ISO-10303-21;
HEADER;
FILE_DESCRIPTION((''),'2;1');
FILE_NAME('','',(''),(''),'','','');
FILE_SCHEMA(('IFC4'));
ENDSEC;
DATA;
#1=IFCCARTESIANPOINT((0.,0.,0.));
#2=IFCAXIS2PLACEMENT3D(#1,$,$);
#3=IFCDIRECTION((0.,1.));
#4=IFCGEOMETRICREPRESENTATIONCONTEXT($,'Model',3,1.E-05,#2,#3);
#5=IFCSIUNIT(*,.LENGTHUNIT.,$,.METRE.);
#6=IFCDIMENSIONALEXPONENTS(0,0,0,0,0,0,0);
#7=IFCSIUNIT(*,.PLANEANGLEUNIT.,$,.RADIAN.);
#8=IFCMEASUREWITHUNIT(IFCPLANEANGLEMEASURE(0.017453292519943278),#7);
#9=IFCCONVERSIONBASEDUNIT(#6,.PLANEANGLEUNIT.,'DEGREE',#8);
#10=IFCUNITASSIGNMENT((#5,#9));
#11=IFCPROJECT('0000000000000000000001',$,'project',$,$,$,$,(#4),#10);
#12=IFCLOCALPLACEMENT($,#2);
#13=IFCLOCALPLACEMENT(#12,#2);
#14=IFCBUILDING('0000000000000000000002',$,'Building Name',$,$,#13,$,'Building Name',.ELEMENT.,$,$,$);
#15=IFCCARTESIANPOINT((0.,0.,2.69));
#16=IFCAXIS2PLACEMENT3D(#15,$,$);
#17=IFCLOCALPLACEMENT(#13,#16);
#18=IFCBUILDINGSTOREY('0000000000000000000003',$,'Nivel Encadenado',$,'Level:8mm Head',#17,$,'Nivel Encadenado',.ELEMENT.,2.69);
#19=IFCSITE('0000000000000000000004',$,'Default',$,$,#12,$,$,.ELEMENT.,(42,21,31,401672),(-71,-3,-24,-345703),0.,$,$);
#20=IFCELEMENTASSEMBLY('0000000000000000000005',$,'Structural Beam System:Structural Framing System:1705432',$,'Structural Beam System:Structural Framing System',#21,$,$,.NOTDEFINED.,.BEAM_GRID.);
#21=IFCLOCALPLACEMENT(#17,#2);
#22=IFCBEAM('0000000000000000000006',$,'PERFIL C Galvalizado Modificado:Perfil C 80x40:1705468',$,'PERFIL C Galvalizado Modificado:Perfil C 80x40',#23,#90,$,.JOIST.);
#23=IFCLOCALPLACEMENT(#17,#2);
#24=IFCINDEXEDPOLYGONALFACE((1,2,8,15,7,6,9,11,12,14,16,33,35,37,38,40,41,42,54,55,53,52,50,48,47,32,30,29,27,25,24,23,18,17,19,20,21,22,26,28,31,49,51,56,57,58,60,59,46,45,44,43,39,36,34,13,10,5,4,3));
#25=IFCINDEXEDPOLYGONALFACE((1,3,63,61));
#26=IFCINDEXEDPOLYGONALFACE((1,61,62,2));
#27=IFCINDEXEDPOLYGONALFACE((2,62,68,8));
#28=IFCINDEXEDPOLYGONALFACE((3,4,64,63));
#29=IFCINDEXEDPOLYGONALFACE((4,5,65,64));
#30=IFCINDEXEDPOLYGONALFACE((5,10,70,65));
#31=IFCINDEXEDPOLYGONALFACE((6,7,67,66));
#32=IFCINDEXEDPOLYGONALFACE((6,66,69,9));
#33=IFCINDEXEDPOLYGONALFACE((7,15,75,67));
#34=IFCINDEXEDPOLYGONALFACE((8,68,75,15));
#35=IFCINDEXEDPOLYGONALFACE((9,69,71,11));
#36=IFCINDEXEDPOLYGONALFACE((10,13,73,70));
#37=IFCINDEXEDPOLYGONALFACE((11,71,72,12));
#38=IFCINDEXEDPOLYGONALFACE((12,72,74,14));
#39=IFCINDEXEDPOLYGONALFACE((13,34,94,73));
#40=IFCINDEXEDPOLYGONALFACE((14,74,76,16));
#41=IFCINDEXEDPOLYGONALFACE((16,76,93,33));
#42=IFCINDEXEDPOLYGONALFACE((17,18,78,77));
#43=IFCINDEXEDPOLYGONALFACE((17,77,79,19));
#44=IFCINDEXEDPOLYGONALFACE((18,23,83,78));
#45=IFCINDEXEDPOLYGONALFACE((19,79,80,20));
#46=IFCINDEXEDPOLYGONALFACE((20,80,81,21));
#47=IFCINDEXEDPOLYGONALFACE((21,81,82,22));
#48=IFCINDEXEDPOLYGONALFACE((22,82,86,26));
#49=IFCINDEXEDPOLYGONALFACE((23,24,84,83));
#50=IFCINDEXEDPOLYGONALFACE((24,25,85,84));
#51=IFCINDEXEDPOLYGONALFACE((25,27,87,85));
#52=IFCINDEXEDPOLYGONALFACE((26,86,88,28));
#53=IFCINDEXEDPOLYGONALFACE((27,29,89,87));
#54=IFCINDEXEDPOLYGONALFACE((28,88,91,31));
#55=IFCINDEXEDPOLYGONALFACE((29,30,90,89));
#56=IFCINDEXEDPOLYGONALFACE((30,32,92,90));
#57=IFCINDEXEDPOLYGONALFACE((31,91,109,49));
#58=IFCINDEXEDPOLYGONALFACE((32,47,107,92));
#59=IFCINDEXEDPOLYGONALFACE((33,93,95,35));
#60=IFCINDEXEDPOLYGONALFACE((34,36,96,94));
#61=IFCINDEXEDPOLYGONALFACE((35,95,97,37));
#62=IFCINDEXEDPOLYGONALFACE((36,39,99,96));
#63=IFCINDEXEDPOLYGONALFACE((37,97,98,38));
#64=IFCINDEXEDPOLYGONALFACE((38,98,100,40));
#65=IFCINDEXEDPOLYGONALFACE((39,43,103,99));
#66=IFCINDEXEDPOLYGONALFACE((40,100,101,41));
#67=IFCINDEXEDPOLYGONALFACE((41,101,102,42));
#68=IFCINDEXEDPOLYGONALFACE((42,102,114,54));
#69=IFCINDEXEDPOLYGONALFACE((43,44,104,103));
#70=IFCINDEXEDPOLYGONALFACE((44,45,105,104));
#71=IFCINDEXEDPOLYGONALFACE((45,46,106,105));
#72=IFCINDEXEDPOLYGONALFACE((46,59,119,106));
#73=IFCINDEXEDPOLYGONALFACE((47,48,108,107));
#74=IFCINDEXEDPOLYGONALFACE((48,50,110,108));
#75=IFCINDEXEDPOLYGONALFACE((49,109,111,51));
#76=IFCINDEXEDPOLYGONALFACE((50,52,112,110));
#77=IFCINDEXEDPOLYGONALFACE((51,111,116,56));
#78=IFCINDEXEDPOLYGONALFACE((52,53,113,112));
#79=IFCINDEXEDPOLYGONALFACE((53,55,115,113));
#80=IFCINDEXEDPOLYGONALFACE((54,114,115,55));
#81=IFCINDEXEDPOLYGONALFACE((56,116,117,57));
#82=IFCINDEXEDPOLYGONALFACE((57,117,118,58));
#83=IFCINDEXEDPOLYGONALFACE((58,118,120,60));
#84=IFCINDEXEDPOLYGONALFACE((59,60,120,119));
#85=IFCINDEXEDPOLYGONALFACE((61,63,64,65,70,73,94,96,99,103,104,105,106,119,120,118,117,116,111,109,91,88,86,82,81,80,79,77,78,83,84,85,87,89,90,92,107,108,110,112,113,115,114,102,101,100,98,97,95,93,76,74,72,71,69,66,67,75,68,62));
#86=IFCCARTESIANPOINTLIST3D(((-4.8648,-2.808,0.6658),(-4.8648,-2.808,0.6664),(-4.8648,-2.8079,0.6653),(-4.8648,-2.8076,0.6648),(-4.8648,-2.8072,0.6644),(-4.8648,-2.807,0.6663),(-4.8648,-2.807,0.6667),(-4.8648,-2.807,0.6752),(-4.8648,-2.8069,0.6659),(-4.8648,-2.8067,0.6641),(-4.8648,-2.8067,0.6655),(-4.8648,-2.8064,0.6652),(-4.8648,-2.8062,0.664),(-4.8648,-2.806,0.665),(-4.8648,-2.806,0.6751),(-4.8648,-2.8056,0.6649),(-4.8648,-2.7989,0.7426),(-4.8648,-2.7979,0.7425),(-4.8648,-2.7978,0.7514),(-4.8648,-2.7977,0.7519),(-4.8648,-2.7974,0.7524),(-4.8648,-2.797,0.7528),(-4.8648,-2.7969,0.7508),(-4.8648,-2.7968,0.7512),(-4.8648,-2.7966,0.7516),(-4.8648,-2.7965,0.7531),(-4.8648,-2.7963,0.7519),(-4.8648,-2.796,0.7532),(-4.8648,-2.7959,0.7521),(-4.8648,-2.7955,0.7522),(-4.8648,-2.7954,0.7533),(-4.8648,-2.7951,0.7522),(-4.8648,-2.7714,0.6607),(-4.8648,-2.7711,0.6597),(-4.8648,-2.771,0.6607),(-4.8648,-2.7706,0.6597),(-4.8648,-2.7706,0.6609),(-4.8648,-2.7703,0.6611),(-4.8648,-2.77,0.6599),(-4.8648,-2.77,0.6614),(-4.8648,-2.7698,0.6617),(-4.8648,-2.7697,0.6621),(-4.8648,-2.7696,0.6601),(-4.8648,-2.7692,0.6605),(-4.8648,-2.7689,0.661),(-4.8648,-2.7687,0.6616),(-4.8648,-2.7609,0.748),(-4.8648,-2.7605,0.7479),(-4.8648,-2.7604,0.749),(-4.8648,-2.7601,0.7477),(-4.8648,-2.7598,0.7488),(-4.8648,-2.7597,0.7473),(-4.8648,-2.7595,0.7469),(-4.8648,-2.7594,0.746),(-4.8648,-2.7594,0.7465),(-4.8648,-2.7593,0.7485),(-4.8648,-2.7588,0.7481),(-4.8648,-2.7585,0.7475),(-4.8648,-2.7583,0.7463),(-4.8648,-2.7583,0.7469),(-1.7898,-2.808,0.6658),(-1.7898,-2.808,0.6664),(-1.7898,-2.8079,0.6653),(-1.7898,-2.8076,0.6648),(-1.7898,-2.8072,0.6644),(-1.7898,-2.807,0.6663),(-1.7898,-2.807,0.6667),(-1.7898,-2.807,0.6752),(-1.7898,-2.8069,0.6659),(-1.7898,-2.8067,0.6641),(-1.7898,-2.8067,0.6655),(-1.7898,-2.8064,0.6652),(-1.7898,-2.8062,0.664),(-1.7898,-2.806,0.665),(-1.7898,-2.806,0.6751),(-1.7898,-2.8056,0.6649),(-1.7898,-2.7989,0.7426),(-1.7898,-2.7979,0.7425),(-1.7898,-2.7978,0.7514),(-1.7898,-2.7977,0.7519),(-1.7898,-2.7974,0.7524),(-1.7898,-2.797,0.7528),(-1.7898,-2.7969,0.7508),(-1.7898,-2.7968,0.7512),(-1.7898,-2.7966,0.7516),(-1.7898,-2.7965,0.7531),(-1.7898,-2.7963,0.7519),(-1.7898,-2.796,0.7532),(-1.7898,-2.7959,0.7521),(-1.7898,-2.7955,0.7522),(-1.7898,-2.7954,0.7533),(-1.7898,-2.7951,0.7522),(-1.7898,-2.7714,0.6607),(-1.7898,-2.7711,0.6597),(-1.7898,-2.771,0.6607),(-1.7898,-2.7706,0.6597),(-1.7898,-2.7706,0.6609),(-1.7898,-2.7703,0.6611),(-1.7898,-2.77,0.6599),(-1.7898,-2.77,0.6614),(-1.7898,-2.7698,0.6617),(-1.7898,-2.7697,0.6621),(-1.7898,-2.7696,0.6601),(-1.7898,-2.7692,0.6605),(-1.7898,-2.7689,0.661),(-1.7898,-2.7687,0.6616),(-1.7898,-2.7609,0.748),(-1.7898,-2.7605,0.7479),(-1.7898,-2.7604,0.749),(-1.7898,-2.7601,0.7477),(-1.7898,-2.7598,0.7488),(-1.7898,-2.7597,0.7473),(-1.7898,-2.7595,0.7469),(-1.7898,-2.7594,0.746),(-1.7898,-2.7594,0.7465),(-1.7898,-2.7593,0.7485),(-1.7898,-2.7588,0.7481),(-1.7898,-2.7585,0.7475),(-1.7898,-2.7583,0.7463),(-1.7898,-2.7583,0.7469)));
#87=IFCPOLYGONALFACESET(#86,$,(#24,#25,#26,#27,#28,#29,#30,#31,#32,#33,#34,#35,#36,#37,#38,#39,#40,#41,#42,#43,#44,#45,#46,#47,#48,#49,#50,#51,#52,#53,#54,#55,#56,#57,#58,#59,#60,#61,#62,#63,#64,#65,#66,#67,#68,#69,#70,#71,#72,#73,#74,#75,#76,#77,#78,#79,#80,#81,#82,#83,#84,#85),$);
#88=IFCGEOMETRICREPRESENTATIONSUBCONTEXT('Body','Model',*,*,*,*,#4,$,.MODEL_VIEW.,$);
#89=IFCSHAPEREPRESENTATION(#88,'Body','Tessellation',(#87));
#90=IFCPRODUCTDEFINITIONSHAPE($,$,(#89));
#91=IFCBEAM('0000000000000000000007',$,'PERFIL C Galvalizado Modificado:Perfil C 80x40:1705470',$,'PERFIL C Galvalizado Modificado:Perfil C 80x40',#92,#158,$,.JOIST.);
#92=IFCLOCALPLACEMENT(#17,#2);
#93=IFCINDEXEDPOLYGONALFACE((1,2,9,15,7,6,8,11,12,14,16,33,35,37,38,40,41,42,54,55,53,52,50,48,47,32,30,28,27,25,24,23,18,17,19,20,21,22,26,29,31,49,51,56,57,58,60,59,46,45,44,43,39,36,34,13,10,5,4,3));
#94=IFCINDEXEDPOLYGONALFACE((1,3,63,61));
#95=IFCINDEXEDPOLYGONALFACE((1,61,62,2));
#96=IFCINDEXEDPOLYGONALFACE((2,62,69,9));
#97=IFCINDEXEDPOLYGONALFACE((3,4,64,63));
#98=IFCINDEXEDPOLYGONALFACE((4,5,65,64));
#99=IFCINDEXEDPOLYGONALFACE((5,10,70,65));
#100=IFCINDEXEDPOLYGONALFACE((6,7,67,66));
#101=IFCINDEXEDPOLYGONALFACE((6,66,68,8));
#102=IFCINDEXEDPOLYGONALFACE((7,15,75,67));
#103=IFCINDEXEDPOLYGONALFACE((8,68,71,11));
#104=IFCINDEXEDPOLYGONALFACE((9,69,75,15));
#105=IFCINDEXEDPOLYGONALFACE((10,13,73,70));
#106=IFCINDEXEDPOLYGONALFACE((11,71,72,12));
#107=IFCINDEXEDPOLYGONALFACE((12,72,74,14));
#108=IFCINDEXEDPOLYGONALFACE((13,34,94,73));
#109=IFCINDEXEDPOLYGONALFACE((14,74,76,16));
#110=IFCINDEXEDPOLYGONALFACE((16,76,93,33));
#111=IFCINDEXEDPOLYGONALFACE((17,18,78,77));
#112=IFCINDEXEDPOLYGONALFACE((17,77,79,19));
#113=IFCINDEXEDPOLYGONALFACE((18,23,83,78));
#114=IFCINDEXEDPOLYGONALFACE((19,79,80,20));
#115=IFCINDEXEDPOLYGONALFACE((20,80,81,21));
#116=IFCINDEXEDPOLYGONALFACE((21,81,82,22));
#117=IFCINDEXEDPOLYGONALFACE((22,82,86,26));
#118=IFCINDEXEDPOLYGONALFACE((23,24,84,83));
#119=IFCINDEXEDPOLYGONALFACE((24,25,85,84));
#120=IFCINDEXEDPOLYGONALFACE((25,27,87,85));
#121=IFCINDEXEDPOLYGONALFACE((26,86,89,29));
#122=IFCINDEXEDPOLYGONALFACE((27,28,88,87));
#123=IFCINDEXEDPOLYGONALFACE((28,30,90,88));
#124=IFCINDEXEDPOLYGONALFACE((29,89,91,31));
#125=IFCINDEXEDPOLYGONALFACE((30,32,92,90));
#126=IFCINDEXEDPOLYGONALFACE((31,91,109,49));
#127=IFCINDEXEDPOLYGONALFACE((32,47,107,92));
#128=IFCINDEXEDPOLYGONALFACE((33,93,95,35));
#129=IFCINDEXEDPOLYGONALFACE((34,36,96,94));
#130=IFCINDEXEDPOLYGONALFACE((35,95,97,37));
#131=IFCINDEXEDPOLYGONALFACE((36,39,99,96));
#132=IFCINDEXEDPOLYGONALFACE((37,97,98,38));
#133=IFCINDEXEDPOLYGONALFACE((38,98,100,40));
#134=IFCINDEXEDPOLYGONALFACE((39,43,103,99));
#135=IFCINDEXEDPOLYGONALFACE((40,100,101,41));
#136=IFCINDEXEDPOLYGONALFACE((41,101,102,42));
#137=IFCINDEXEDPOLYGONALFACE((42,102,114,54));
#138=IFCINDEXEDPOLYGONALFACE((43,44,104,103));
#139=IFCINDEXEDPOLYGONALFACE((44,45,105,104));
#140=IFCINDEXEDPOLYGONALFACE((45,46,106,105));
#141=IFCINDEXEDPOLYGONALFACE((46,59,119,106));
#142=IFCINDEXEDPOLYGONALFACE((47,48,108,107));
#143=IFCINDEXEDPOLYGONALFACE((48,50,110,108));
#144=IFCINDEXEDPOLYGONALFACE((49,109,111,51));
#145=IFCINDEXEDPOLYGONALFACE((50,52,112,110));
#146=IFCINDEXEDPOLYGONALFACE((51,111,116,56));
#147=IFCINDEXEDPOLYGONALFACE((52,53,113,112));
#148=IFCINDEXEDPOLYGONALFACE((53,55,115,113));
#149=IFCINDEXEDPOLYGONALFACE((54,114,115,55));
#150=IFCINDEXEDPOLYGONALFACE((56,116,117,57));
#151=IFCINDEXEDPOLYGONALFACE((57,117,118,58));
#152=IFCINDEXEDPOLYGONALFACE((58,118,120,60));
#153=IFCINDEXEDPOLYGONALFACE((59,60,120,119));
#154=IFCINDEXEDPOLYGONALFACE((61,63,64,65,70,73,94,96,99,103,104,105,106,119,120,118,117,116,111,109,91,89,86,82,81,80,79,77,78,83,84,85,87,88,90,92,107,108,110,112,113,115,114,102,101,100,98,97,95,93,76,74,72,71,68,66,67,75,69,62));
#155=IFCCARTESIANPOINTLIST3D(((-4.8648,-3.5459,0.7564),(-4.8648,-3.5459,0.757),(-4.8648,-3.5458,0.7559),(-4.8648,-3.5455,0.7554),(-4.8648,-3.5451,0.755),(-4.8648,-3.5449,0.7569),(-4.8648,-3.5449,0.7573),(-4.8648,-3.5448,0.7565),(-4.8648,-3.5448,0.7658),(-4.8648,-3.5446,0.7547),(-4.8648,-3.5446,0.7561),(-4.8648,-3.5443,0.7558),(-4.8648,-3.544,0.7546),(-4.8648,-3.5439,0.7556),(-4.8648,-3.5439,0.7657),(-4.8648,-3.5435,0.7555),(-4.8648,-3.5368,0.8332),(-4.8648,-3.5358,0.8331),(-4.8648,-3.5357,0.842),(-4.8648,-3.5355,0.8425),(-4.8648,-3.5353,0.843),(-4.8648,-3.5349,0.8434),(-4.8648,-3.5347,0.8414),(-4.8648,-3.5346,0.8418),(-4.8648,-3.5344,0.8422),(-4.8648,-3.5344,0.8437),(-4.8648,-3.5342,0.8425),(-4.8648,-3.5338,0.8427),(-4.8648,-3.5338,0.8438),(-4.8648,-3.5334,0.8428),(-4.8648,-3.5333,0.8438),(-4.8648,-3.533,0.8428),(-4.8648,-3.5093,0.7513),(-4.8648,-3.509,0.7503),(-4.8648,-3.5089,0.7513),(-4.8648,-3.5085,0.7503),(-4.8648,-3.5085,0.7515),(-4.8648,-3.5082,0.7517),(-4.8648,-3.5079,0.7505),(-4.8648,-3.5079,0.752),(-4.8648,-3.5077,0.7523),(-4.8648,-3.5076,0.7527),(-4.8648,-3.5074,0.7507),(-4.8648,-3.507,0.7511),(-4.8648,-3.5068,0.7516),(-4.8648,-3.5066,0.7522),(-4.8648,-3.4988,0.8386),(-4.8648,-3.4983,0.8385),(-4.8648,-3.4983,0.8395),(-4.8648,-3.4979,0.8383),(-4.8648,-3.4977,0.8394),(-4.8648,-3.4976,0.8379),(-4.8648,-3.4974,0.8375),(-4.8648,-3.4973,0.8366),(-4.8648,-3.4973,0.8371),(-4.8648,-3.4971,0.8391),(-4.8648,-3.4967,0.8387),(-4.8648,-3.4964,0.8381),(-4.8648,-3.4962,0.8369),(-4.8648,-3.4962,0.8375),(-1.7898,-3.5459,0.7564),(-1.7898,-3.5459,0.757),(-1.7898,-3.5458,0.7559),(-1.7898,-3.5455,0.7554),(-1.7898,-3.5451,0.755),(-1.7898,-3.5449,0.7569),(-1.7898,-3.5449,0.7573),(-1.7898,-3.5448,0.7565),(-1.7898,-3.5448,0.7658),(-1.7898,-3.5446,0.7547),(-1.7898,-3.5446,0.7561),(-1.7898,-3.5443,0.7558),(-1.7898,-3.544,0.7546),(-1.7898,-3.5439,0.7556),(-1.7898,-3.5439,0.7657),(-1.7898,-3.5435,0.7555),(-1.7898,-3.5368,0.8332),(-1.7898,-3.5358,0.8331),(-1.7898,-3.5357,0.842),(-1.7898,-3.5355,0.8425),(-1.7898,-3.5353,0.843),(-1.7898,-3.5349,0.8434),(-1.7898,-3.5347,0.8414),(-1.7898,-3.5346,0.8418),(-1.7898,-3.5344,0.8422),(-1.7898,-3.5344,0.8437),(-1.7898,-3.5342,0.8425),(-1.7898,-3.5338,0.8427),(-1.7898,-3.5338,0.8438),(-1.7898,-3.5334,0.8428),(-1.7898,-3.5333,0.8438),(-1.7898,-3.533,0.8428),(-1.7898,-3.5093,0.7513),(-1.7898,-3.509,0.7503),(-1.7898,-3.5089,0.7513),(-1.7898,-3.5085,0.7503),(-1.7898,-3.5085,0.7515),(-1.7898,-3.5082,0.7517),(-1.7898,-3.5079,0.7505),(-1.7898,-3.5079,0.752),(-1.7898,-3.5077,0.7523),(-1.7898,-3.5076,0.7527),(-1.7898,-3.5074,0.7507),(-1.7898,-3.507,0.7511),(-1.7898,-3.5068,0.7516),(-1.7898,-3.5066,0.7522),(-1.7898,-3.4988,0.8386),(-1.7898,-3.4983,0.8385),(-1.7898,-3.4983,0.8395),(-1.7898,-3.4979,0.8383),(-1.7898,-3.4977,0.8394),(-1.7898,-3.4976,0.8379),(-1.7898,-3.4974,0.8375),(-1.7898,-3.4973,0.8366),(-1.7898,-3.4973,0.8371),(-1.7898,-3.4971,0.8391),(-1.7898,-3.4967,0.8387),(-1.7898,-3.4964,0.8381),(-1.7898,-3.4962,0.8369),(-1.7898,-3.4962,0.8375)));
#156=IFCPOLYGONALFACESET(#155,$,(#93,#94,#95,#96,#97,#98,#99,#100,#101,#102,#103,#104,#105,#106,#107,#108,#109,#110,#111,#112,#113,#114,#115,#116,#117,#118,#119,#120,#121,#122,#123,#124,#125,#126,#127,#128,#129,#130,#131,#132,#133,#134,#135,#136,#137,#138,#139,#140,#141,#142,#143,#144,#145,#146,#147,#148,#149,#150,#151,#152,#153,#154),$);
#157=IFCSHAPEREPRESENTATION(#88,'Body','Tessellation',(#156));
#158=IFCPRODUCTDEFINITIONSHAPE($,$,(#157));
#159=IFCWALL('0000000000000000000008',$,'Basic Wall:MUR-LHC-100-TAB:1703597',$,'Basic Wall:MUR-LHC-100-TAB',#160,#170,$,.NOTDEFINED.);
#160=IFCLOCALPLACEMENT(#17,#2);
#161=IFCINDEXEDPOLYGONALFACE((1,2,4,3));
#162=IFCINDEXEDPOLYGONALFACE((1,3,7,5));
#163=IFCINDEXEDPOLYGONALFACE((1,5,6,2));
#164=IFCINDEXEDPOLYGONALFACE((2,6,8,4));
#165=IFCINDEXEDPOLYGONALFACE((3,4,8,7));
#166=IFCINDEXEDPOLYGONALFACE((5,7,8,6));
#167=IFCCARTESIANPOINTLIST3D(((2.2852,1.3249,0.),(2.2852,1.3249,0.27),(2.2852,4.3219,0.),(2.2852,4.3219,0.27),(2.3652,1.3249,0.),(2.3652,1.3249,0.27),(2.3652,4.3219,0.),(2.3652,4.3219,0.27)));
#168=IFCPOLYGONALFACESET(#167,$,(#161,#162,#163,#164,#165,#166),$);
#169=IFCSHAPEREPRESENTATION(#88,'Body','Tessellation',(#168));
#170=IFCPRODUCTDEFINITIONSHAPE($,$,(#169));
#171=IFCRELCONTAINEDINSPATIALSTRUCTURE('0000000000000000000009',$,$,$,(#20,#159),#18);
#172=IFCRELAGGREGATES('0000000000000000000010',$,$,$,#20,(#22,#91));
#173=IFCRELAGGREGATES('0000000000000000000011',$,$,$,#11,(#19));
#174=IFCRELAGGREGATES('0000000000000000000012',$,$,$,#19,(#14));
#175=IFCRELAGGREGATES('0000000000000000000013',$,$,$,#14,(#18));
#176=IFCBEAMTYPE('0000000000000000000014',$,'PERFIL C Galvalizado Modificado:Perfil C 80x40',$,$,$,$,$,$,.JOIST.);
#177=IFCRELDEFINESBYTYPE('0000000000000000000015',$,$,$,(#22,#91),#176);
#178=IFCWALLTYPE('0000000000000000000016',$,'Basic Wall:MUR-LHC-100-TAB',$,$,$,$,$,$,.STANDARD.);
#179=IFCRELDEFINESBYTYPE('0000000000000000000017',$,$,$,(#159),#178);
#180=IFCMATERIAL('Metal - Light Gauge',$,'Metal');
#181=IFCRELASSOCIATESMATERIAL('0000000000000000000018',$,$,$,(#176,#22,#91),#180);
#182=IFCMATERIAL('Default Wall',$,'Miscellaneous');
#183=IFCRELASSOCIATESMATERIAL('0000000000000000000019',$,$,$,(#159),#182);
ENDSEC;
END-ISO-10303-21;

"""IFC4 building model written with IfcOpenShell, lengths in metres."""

from ifc_helpers import new_model, entity, si_unit, converted_unit, direction, frame, origin, place, context, subcontext, project, spatial, line, arc, indexed_curve, outline, extrude, source, transform, mapped, material, type_object, type_shapes, element, aggregate, save


model = new_model("IFC4")

# Units and contexts
model_context = context("Model", 3, precision=1e-05, world=origin(), true_north=direction((0.0, 1.0)))
body_context = subcontext(model_context, "Body", "Model", "MODEL_VIEW")
ifc_project = project(units=[si_unit("LENGTHUNIT", "METRE"), converted_unit("PLANEANGLEUNIT", "DEGREE", entity("IfcPlaneAngleMeasure", 0.017453292519943278), si_unit("PLANEANGLEUNIT", "RADIAN"), dimensions=[0, 0, 0, 0, 0, 0, 0])], contexts=[model_context])

# Site, building, storey
site_placement = place(None, origin())
site = spatial("IfcSite", under=ifc_project, at=site_placement, Name="Default", CompositionType="ELEMENT", RefLatitude=(42, 21, 31, 401672), RefLongitude=(-71, -3, -24, -345703), RefElevation=0.0)
building_placement = place(site_placement, origin())
building = spatial("IfcBuilding", under=site, at=building_placement, Name="Building Name", LongName="Building Name", CompositionType="ELEMENT")
storey_placement = place(building_placement, frame((0.0, 0.0, 2.69)))
storey = spatial("IfcBuildingStorey", under=building, at=storey_placement, Name="Nivel Encadenado", ObjectType="Level:8mm Head", LongName="Nivel Encadenado", CompositionType="ELEMENT", Elevation=2.69)

# Element assembly, beams
ifc_material_1 = material(Name="Metal - Light Gauge", Category="Metal")
assembly_1_placement = place(storey_placement, origin())
assembly_1 = element("IfcElementAssembly", 1, at=assembly_1_placement, inside=storey, Name="Structural Beam System:Structural Framing System:1705432", ObjectType="Structural Beam System:Structural Framing System", AssemblyPlace="NOTDEFINED", PredefinedType="BEAM_GRID")
beam_type_1 = type_object("IfcBeamType", Name="PERFIL C Galvalizado Modificado:Perfil C 80x40", PredefinedType="JOIST", material=ifc_material_1)
shared_shape_1 = source(origin(), body_context, "Body", "SweptSolid", [
    extrude(outline(indexed_curve([(-0.0428, -0.0237), (0.0426, -0.0237), (0.0443, -0.023), (0.045, -0.0214), (0.045, 0.0139), (0.0443, 0.0154), (0.0428, 0.0161), (0.034, 0.0161), (0.034, 0.0151), (0.0424, 0.0151), (0.0435, 0.0146), (0.044, 0.0135), (0.044, -0.021), (0.0435, -0.0222), (0.0422, -0.0227), (-0.0424, -0.0227), (-0.0435, -0.0223), (-0.0439, -0.0212), (-0.0439, 0.0133), (-0.0435, 0.0144), (-0.0424, 0.0149), (-0.0339, 0.0149), (-0.0339, 0.0159), (-0.0428, 0.0159), (-0.0443, 0.0152), (-0.0449, 0.0137), (-0.0449, -0.0216), (-0.0443, -0.0231)], segments=[line(1, 2), arc(2, 3, 4), line(4, 5), arc(5, 6, 7), line(7, 8, 9, 10), arc(10, 11, 12), line(12, 13), arc(13, 14, 15), line(15, 16), arc(16, 17, 18), line(18, 19), arc(19, 20, 21), line(21, 22, 23, 24), arc(24, 25, 26), line(26, 27), arc(27, 28, 1)], self_intersect=False)), frame((-1.5375, -0.0037, 0.0), z_axis=(1.0, 0.0, 0.0), x_axis=(0.0, 0.0, 1.0)), (0.0, 0.0, 1.0), 3.075),
])
type_shapes(beam_type_1, [shared_shape_1])
beam_1_placement = place(assembly_1_placement, frame((-3.3273, -2.7834, 0.7065), z_axis=(0.0, 0.121869, 0.992546), x_axis=(1.0, 0.0, 0.0)))
beam_1 = element("IfcBeam", 2, at=beam_1_placement, type_object=beam_type_1, material=ifc_material_1, Name="PERFIL C Galvalizado Modificado:Perfil C 80x40:1705468", ObjectType="PERFIL C Galvalizado Modificado:Perfil C 80x40", PredefinedType="JOIST", context=body_context, shape_type="MappedRepresentation", body=[
    mapped(shared_shape_1, transform((0.0, 0.0, 0.0), scale=1.0)),
])
beam_2_placement = place(assembly_1_placement, frame((-3.3273, -3.5213, 0.7971), z_axis=(0.0, 0.121869, 0.992546), x_axis=(1.0, 0.0, 0.0)))
beam_2 = element("IfcBeam", 3, at=beam_2_placement, type_object=beam_type_1, material=ifc_material_1, Name="PERFIL C Galvalizado Modificado:Perfil C 80x40:1705470", ObjectType="PERFIL C Galvalizado Modificado:Perfil C 80x40", PredefinedType="JOIST", context=body_context, shape_type="MappedRepresentation", body=[
    mapped(shared_shape_1, transform((0.0, 0.0, 0.0), scale=1.0)),
])
aggregate(assembly_1, [beam_1, beam_2])

# Wall
ifc_material_2 = material(Name="Default Wall", Category="Miscellaneous")
wall_type_1 = type_object("IfcWallType", Name="Basic Wall:MUR-LHC-100-TAB", PredefinedType="STANDARD")
wall_1_placement = place(storey_placement, frame((2.3252, 1.3249, 0.0), z_axis=(0.0, 0.0, 1.0), x_axis=(0.0, 1.0, 0.0)))
element("IfcWall", 4, at=wall_1_placement, inside=storey, type_object=wall_type_1, material=ifc_material_2, Name="Basic Wall:MUR-LHC-100-TAB:1703597", ObjectType="Basic Wall:MUR-LHC-100-TAB", PredefinedType="NOTDEFINED", context=body_context, shape_type="SweptSolid", body=[
    extrude(outline(indexed_curve([(2.997, 0.04), (0.0, 0.04), (0.0, -0.04), (2.997, -0.04), (2.997, 0.04)], self_intersect=False)), origin(), (0.0, 0.0, 1.0), 0.27),
])

save(model, "model.ifc")
